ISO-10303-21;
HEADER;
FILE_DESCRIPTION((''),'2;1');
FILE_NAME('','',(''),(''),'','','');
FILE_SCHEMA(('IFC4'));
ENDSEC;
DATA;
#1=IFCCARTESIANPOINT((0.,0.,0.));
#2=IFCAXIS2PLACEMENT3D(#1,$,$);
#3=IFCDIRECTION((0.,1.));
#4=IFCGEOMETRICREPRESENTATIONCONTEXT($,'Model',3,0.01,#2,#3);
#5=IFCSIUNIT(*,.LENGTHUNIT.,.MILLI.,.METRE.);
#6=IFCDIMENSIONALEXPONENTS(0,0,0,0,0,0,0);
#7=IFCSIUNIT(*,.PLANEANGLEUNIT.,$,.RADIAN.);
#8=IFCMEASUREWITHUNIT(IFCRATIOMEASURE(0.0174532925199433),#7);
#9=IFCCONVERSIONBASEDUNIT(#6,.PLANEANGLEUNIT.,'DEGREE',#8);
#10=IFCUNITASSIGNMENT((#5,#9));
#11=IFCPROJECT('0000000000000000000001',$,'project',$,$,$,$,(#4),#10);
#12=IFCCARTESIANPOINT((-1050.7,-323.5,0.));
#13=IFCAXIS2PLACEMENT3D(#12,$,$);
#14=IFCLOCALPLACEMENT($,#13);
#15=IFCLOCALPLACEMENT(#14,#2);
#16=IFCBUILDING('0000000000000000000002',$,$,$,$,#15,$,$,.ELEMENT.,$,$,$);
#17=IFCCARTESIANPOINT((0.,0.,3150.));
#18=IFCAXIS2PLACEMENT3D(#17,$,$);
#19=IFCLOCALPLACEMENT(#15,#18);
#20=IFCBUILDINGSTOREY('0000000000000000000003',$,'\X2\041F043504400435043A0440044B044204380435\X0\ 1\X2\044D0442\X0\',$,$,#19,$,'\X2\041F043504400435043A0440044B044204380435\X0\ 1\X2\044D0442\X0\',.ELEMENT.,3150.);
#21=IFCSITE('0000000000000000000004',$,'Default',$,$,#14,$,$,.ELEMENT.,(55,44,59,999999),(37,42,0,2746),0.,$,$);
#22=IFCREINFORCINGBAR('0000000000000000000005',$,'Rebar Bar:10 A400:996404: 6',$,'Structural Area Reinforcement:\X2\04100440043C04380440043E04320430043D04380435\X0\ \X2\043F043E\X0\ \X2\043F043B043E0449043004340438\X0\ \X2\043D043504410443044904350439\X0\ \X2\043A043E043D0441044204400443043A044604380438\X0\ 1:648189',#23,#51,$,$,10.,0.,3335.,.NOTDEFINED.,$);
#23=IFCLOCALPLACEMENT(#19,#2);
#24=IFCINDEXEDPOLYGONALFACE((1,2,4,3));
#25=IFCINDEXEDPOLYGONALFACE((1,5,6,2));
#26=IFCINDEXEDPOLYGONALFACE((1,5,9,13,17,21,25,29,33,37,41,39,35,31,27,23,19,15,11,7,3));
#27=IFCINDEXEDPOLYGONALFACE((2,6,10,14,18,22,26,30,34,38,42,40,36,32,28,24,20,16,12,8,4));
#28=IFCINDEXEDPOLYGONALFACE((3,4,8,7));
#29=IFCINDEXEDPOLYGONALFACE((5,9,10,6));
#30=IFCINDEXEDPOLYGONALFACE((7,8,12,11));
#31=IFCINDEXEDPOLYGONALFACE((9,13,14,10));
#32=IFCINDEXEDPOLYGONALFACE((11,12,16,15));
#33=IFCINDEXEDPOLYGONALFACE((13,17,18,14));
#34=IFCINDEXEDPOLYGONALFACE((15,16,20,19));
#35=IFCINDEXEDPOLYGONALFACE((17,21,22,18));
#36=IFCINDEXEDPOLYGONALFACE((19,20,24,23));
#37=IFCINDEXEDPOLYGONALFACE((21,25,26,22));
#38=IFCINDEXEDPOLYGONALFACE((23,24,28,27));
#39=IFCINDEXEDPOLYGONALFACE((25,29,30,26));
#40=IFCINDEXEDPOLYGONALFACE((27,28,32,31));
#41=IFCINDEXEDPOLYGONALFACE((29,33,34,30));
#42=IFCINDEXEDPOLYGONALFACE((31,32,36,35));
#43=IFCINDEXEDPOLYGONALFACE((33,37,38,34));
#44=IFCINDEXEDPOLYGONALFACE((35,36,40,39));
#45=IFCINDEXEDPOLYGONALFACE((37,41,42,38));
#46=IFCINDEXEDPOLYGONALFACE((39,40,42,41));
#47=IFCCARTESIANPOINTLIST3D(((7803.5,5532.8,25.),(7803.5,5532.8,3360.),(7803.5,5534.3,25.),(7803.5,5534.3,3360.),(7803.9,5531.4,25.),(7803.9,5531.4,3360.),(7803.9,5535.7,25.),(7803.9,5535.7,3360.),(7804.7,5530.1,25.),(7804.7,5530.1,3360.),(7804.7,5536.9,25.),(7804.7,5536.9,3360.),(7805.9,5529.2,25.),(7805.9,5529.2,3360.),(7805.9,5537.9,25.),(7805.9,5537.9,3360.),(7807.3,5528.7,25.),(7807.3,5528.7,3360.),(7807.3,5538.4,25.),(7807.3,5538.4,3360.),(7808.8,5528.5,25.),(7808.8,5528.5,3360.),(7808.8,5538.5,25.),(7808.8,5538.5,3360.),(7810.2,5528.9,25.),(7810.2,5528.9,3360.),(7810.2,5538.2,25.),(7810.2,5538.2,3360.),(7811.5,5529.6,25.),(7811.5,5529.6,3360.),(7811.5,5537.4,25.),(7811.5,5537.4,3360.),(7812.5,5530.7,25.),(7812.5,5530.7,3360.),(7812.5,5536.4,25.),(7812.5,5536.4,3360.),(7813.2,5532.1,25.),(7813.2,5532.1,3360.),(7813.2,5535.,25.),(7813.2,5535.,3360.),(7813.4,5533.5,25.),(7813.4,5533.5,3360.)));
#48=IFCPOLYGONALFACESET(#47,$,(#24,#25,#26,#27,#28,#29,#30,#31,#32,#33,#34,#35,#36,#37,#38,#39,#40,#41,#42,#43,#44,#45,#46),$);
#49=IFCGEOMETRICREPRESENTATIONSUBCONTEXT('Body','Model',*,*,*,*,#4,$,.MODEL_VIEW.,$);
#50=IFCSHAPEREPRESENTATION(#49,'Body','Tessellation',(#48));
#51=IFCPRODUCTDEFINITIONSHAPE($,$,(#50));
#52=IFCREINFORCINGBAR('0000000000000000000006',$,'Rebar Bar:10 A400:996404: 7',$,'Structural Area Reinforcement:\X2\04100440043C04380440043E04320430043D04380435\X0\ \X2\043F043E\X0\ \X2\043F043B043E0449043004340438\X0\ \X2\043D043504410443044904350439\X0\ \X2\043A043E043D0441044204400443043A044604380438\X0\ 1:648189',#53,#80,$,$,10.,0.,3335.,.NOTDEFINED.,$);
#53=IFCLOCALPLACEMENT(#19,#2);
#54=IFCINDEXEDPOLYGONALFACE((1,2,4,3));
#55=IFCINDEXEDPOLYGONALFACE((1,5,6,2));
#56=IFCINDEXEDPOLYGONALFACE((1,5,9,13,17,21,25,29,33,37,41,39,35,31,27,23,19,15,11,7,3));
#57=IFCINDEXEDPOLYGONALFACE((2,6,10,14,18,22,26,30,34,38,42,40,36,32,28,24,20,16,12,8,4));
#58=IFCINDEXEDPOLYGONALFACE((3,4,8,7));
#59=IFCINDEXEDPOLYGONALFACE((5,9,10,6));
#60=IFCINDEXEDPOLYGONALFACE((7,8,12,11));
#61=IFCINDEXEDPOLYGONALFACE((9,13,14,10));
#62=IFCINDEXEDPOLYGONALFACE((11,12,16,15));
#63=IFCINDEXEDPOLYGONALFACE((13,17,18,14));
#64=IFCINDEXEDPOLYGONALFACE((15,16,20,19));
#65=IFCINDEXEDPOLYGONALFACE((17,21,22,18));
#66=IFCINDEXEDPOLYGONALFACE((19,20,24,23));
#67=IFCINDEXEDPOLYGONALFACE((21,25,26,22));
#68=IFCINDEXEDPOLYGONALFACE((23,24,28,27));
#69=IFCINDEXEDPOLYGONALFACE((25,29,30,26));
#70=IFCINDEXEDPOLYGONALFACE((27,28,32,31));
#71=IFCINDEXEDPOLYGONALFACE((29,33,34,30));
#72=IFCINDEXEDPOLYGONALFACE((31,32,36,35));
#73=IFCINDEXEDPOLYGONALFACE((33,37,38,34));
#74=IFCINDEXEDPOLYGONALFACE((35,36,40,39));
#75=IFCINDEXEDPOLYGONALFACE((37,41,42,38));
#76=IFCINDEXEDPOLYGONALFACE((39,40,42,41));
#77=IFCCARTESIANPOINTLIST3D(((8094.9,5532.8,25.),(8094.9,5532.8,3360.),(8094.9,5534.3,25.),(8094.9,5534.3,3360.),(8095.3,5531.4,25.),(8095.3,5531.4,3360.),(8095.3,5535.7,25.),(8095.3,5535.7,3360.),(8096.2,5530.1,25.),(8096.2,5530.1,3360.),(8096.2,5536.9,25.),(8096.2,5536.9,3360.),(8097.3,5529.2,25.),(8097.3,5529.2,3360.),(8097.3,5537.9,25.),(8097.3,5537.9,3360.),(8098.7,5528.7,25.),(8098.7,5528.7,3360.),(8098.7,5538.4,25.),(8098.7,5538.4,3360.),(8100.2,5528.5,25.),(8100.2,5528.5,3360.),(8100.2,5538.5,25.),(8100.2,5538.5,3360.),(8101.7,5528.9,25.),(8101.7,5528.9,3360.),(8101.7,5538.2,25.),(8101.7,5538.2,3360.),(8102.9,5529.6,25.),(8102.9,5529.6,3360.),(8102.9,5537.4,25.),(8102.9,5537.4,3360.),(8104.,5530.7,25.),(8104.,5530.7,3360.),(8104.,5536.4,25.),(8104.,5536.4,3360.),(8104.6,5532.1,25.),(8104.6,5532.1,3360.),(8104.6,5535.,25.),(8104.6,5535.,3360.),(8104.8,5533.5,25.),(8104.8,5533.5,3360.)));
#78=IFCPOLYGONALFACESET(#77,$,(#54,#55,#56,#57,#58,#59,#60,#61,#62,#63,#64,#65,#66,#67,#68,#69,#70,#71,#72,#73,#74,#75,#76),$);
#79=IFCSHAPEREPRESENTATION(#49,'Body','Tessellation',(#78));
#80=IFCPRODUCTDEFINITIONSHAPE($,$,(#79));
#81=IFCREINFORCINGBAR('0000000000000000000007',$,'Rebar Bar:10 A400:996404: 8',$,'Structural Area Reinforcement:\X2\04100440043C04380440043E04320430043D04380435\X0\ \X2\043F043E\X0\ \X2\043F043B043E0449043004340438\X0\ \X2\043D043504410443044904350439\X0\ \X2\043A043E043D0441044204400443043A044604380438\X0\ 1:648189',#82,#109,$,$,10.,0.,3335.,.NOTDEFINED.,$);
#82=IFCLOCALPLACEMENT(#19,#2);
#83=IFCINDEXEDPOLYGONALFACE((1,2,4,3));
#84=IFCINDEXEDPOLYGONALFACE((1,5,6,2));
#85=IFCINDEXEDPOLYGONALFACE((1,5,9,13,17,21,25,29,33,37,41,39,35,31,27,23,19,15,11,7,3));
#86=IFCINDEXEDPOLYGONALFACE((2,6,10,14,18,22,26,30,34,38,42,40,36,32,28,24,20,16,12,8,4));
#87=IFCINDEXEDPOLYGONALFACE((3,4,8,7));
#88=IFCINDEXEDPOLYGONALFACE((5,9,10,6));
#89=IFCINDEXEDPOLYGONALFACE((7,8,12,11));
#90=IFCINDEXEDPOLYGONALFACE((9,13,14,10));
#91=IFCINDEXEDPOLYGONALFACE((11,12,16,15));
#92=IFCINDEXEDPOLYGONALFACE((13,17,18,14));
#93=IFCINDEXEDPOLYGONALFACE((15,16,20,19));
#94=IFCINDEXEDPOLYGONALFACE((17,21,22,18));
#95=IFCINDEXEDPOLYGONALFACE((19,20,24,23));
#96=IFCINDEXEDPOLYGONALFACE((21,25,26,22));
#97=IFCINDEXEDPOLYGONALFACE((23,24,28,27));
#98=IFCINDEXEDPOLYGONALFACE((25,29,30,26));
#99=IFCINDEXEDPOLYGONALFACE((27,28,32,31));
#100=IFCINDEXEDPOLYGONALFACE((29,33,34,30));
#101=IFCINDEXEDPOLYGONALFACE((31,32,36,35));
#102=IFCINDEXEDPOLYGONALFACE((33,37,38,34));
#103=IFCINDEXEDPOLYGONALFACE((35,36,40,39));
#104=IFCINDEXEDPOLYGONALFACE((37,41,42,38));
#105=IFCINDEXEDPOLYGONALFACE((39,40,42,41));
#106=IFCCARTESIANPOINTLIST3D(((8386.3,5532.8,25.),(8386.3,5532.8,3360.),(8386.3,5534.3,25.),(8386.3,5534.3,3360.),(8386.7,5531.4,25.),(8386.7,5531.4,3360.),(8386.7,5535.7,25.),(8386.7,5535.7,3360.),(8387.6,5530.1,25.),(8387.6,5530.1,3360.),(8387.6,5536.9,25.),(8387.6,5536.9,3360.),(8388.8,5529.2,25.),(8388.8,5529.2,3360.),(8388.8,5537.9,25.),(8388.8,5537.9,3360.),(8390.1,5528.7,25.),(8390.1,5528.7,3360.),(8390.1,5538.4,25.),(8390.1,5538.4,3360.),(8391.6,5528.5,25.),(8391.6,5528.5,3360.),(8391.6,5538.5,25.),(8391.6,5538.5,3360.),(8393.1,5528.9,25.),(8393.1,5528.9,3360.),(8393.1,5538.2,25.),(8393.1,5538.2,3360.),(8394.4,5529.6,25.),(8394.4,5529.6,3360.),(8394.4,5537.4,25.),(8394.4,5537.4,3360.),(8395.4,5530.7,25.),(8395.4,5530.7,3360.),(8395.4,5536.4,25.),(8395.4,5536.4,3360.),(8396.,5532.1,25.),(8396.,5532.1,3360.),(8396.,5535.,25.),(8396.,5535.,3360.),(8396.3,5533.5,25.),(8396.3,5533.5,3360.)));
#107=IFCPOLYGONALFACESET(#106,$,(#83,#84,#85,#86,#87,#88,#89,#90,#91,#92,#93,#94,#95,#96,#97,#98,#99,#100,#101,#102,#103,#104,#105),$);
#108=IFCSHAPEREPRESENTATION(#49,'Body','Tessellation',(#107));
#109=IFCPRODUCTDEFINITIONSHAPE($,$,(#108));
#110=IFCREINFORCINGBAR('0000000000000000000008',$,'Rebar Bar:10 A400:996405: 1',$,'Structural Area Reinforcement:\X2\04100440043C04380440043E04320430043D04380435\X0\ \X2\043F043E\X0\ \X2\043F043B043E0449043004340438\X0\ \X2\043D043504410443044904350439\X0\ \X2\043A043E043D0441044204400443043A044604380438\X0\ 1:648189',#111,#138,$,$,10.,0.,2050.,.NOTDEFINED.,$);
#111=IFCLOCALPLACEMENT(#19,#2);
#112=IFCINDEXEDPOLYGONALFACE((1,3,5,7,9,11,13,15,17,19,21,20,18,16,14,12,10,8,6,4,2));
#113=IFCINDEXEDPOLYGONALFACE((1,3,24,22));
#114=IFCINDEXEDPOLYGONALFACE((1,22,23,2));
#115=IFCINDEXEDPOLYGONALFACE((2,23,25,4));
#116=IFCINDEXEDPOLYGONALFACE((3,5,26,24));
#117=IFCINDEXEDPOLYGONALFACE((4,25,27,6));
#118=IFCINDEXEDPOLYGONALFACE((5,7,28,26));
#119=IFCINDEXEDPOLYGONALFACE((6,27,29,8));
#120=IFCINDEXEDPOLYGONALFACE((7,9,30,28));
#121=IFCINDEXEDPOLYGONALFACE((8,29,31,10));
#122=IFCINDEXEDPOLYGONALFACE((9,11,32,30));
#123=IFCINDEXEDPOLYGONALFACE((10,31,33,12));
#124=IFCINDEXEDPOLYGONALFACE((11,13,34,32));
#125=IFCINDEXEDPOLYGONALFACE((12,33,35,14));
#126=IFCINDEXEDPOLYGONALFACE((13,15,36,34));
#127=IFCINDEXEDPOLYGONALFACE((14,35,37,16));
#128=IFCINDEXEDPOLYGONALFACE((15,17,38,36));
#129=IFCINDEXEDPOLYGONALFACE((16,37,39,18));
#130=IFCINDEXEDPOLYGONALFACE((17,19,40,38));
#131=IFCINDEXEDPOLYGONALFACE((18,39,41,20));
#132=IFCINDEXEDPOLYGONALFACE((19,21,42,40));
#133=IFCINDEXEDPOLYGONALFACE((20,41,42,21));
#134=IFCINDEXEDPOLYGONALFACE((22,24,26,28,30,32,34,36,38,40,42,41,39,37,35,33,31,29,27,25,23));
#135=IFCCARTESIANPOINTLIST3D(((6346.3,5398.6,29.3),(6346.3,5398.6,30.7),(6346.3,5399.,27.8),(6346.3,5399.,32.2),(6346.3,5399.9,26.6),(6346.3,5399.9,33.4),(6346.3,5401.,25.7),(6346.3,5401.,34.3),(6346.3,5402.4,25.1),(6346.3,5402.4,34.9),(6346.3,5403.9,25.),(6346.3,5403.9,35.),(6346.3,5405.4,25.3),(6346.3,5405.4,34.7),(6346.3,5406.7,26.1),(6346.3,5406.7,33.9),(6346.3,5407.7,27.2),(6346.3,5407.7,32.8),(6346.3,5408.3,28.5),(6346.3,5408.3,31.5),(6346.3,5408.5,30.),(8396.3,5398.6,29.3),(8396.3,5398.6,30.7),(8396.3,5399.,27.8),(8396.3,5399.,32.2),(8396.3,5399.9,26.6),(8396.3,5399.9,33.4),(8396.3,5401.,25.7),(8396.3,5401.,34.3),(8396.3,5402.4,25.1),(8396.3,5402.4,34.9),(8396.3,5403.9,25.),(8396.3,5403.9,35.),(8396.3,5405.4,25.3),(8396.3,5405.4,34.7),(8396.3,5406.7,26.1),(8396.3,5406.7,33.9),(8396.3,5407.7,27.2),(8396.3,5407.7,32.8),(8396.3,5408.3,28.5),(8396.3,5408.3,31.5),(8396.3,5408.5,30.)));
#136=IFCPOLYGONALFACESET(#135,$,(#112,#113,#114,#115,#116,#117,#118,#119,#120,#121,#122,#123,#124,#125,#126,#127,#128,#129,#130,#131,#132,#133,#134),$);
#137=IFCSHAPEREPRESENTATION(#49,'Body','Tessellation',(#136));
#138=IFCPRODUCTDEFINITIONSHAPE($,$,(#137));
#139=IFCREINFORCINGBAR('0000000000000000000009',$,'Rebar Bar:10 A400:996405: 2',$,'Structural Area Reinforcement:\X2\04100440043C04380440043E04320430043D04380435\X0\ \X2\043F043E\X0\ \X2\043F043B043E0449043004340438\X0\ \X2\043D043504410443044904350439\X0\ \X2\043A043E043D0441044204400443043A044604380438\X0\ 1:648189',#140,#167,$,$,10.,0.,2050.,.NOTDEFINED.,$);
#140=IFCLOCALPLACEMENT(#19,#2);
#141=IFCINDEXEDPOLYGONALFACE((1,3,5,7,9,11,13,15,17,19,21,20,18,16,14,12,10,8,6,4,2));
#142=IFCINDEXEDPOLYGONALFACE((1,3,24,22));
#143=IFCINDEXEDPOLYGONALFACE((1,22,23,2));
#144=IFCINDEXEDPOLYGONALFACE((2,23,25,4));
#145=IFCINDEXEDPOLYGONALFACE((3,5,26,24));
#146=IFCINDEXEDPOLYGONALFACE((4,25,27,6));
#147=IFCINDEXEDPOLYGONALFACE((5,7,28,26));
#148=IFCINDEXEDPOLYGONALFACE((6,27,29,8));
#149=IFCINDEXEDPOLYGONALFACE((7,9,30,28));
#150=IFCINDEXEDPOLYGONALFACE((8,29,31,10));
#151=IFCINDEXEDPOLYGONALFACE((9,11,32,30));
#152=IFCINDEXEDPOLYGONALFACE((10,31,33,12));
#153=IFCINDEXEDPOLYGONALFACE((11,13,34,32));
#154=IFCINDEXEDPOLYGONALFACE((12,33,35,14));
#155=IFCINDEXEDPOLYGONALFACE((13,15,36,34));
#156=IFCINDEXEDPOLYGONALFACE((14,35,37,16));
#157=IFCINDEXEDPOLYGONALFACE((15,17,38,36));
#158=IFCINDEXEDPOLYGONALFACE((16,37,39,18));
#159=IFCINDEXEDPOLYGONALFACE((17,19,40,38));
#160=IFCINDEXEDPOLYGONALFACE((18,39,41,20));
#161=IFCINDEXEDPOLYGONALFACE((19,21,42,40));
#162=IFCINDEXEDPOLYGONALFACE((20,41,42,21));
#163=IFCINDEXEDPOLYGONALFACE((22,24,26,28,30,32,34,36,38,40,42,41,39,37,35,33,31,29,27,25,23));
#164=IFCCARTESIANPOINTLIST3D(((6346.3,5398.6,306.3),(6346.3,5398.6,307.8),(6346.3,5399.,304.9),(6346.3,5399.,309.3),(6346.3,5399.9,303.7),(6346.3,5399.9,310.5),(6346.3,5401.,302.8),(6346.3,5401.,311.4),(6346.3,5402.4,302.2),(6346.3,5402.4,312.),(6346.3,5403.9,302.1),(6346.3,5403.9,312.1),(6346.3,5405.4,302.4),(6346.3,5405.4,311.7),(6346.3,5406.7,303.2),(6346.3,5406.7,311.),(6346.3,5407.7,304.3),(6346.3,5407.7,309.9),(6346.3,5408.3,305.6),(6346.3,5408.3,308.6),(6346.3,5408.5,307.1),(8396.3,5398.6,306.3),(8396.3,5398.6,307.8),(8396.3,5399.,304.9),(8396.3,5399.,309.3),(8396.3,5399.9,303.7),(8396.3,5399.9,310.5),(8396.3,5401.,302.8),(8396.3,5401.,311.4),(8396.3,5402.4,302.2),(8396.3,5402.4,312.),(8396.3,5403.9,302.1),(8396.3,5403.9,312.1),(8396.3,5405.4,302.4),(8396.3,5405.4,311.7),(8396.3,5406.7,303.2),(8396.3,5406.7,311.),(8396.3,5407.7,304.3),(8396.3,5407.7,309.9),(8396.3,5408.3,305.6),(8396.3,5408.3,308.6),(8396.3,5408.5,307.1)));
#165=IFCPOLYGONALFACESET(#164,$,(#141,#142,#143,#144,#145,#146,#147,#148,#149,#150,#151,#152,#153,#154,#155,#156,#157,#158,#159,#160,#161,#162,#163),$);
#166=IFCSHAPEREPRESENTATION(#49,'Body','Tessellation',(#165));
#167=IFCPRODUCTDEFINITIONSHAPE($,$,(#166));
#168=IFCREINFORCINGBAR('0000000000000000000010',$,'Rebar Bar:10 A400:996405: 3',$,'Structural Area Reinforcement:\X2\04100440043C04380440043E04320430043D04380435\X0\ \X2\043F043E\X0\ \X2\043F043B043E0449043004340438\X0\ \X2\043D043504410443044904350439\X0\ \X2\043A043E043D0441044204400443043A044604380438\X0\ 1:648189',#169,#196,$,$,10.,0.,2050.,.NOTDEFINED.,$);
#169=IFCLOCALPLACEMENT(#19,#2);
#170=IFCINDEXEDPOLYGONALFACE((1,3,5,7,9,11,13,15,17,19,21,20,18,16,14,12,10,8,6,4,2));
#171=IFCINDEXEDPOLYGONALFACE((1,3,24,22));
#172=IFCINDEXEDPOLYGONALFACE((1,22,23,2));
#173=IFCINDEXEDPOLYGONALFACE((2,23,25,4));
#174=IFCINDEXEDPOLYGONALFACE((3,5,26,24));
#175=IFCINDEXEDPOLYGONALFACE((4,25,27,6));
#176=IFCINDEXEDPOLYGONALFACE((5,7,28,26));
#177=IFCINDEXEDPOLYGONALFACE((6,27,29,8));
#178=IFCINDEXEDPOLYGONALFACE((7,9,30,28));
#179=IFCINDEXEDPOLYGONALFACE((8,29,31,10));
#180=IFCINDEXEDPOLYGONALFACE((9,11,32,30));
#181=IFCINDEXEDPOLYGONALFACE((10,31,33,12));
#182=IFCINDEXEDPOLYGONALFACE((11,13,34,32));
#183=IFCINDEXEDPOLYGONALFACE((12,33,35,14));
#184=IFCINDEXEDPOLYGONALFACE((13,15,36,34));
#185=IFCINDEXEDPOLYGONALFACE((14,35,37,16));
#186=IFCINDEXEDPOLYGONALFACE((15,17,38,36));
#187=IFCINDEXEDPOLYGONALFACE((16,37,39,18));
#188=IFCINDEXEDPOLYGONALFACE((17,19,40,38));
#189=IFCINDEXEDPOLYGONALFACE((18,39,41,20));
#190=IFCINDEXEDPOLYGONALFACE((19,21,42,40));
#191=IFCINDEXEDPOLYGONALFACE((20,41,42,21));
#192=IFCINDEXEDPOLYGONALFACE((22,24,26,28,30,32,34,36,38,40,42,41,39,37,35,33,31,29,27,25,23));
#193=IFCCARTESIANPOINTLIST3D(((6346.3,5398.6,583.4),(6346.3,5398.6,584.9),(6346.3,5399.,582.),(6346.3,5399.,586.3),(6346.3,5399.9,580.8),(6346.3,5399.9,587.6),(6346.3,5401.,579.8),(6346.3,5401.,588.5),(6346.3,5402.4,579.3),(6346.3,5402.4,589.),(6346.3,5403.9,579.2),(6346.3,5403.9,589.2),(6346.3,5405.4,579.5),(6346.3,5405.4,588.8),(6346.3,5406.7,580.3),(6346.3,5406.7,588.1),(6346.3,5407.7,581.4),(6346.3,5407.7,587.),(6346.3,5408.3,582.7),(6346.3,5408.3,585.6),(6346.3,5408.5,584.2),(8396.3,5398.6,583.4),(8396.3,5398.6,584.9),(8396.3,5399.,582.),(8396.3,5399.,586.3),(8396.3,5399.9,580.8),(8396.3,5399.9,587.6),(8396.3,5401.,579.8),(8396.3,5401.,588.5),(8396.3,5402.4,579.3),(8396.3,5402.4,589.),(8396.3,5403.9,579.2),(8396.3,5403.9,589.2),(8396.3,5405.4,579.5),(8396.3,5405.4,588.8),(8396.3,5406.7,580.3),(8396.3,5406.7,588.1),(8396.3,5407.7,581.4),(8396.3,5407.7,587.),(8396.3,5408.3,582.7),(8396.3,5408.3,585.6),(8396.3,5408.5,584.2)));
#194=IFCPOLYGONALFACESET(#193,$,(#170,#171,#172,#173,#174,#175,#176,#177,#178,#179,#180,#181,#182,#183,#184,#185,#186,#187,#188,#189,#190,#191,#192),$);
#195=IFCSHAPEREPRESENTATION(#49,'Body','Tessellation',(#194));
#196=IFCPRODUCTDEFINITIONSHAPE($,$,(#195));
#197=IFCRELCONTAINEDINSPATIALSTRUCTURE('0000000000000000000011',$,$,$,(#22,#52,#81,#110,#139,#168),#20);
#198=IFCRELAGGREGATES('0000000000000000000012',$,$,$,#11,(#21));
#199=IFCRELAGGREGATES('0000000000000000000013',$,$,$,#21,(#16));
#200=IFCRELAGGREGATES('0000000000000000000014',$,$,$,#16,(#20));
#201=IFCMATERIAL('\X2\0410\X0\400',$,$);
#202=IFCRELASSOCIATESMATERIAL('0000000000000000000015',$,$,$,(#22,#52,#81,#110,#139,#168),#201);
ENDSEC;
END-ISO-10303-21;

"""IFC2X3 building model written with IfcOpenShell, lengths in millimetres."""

from ifc_helpers import new_model, entity, si_unit, converted_unit, direction, frame, origin, place, context, subcontext, project, spatial, material, element, save


model = new_model("IFC2X3")

# Units and contexts
model_context = context("Model", 3, precision=0.01, world=origin(), true_north=direction((0.0, 1.0)))
body_context = subcontext(model_context, "Body", "Model", "MODEL_VIEW")
ifc_project = project(units=[si_unit("LENGTHUNIT", "METRE", prefix="MILLI"), converted_unit("PLANEANGLEUNIT", "DEGREE", entity("IfcRatioMeasure", 0.0174532925199433), si_unit("PLANEANGLEUNIT", "RADIAN"), dimensions=[0, 0, 0, 0, 0, 0, 0])], contexts=[model_context])

# Site, building, storey
site_placement = place(None, frame((-1050.7, -323.5, 0.0)))
site = spatial("IfcSite", under=ifc_project, at=site_placement, Name="Default", CompositionType="ELEMENT", RefLatitude=(55, 44, 59, 999999), RefLongitude=(37, 42, 0, 2746), RefElevation=0.0)
building_placement = place(site_placement, origin())
building = spatial("IfcBuilding", under=site, at=building_placement, CompositionType="ELEMENT")
storey_placement = place(building_placement, frame((0.0, 0.0, 3150.0)))
storey = spatial("IfcBuildingStorey", under=building, at=storey_placement, Name="Перекрытие 1эт", LongName="Перекрытие 1эт", CompositionType="ELEMENT", Elevation=3150.0)

# Reinforcing bars
ifc_material = material(Name="А400")
reinforcing_bar_1_placement = place(storey_placement, origin())
element("IfcReinforcingBar", 1, at=reinforcing_bar_1_placement, inside=storey, material=ifc_material, Name="Rebar Bar:10 A400:996404: 6", ObjectType="Structural Area Reinforcement:Армирование по площади несущей конструкции 1:648189", BarLength=3335.0, BarRole="NOTDEFINED", CrossSectionArea=0.0, NominalDiameter=10.0, context=body_context, shape_type="AdvancedSweptSolid", body=[
    entity("IfcSweptDiskSolid", entity("IfcCompositeCurve", [entity("IfcCompositeCurveSegment", "CONTINUOUS", True, entity("IfcPolyline", [entity("IfcCartesianPoint", [7808.4, 5533.5, 25.0]), entity("IfcCartesianPoint", [7808.4, 5533.5, 3360.0])]))], False), 5.0, None, 0.0, 1.0),
])
reinforcing_bar_2_placement = place(storey_placement, origin())
element("IfcReinforcingBar", 2, at=reinforcing_bar_2_placement, inside=storey, material=ifc_material, Name="Rebar Bar:10 A400:996404: 7", ObjectType="Structural Area Reinforcement:Армирование по площади несущей конструкции 1:648189", BarLength=3335.0, BarRole="NOTDEFINED", CrossSectionArea=0.0, NominalDiameter=10.0, context=body_context, shape_type="AdvancedSweptSolid", body=[
    entity("IfcSweptDiskSolid", entity("IfcCompositeCurve", [entity("IfcCompositeCurveSegment", "CONTINUOUS", True, entity("IfcPolyline", [entity("IfcCartesianPoint", [8099.8, 5533.5, 25.0]), entity("IfcCartesianPoint", [8099.8, 5533.5, 3360.0])]))], False), 5.0, None, 0.0, 1.0),
])
reinforcing_bar_3_placement = place(storey_placement, origin())
element("IfcReinforcingBar", 3, at=reinforcing_bar_3_placement, inside=storey, material=ifc_material, Name="Rebar Bar:10 A400:996404: 8", ObjectType="Structural Area Reinforcement:Армирование по площади несущей конструкции 1:648189", BarLength=3335.0, BarRole="NOTDEFINED", CrossSectionArea=0.0, NominalDiameter=10.0, context=body_context, shape_type="AdvancedSweptSolid", body=[
    entity("IfcSweptDiskSolid", entity("IfcCompositeCurve", [entity("IfcCompositeCurveSegment", "CONTINUOUS", True, entity("IfcPolyline", [entity("IfcCartesianPoint", [8391.3, 5533.5, 25.0]), entity("IfcCartesianPoint", [8391.3, 5533.5, 3360.0])]))], False), 5.0, None, 0.0, 1.0),
])
reinforcing_bar_4_placement = place(storey_placement, origin())
element("IfcReinforcingBar", 4, at=reinforcing_bar_4_placement, inside=storey, material=ifc_material, Name="Rebar Bar:10 A400:996405: 1", ObjectType="Structural Area Reinforcement:Армирование по площади несущей конструкции 1:648189", BarLength=2050.0, BarRole="NOTDEFINED", CrossSectionArea=0.0, NominalDiameter=10.0, context=body_context, shape_type="AdvancedSweptSolid", body=[
    entity("IfcSweptDiskSolid", entity("IfcCompositeCurve", [entity("IfcCompositeCurveSegment", "CONTINUOUS", True, entity("IfcPolyline", [entity("IfcCartesianPoint", [6346.3, 5403.5, 30.0]), entity("IfcCartesianPoint", [8396.3, 5403.5, 30.0])]))], False), 5.0, None, 0.0, 1.0),
])
reinforcing_bar_5_placement = place(storey_placement, origin())
element("IfcReinforcingBar", 5, at=reinforcing_bar_5_placement, inside=storey, material=ifc_material, Name="Rebar Bar:10 A400:996405: 2", ObjectType="Structural Area Reinforcement:Армирование по площади несущей конструкции 1:648189", BarLength=2050.0, BarRole="NOTDEFINED", CrossSectionArea=0.0, NominalDiameter=10.0, context=body_context, shape_type="AdvancedSweptSolid", body=[
    entity("IfcSweptDiskSolid", entity("IfcCompositeCurve", [entity("IfcCompositeCurveSegment", "CONTINUOUS", True, entity("IfcPolyline", [entity("IfcCartesianPoint", [6346.3, 5403.5, 307.1]), entity("IfcCartesianPoint", [8396.3, 5403.5, 307.1])]))], False), 5.0, None, 0.0, 1.0),
])
reinforcing_bar_6_placement = place(storey_placement, origin())
element("IfcReinforcingBar", 6, at=reinforcing_bar_6_placement, inside=storey, material=ifc_material, Name="Rebar Bar:10 A400:996405: 3", ObjectType="Structural Area Reinforcement:Армирование по площади несущей конструкции 1:648189", BarLength=2050.0, BarRole="NOTDEFINED", CrossSectionArea=0.0, NominalDiameter=10.0, context=body_context, shape_type="AdvancedSweptSolid", body=[
    entity("IfcSweptDiskSolid", entity("IfcCompositeCurve", [entity("IfcCompositeCurveSegment", "CONTINUOUS", True, entity("IfcPolyline", [entity("IfcCartesianPoint", [6346.3, 5403.5, 584.2]), entity("IfcCartesianPoint", [8396.3, 5403.5, 584.2])]))], False), 5.0, None, 0.0, 1.0),
])

save(model, "model.ifc")
